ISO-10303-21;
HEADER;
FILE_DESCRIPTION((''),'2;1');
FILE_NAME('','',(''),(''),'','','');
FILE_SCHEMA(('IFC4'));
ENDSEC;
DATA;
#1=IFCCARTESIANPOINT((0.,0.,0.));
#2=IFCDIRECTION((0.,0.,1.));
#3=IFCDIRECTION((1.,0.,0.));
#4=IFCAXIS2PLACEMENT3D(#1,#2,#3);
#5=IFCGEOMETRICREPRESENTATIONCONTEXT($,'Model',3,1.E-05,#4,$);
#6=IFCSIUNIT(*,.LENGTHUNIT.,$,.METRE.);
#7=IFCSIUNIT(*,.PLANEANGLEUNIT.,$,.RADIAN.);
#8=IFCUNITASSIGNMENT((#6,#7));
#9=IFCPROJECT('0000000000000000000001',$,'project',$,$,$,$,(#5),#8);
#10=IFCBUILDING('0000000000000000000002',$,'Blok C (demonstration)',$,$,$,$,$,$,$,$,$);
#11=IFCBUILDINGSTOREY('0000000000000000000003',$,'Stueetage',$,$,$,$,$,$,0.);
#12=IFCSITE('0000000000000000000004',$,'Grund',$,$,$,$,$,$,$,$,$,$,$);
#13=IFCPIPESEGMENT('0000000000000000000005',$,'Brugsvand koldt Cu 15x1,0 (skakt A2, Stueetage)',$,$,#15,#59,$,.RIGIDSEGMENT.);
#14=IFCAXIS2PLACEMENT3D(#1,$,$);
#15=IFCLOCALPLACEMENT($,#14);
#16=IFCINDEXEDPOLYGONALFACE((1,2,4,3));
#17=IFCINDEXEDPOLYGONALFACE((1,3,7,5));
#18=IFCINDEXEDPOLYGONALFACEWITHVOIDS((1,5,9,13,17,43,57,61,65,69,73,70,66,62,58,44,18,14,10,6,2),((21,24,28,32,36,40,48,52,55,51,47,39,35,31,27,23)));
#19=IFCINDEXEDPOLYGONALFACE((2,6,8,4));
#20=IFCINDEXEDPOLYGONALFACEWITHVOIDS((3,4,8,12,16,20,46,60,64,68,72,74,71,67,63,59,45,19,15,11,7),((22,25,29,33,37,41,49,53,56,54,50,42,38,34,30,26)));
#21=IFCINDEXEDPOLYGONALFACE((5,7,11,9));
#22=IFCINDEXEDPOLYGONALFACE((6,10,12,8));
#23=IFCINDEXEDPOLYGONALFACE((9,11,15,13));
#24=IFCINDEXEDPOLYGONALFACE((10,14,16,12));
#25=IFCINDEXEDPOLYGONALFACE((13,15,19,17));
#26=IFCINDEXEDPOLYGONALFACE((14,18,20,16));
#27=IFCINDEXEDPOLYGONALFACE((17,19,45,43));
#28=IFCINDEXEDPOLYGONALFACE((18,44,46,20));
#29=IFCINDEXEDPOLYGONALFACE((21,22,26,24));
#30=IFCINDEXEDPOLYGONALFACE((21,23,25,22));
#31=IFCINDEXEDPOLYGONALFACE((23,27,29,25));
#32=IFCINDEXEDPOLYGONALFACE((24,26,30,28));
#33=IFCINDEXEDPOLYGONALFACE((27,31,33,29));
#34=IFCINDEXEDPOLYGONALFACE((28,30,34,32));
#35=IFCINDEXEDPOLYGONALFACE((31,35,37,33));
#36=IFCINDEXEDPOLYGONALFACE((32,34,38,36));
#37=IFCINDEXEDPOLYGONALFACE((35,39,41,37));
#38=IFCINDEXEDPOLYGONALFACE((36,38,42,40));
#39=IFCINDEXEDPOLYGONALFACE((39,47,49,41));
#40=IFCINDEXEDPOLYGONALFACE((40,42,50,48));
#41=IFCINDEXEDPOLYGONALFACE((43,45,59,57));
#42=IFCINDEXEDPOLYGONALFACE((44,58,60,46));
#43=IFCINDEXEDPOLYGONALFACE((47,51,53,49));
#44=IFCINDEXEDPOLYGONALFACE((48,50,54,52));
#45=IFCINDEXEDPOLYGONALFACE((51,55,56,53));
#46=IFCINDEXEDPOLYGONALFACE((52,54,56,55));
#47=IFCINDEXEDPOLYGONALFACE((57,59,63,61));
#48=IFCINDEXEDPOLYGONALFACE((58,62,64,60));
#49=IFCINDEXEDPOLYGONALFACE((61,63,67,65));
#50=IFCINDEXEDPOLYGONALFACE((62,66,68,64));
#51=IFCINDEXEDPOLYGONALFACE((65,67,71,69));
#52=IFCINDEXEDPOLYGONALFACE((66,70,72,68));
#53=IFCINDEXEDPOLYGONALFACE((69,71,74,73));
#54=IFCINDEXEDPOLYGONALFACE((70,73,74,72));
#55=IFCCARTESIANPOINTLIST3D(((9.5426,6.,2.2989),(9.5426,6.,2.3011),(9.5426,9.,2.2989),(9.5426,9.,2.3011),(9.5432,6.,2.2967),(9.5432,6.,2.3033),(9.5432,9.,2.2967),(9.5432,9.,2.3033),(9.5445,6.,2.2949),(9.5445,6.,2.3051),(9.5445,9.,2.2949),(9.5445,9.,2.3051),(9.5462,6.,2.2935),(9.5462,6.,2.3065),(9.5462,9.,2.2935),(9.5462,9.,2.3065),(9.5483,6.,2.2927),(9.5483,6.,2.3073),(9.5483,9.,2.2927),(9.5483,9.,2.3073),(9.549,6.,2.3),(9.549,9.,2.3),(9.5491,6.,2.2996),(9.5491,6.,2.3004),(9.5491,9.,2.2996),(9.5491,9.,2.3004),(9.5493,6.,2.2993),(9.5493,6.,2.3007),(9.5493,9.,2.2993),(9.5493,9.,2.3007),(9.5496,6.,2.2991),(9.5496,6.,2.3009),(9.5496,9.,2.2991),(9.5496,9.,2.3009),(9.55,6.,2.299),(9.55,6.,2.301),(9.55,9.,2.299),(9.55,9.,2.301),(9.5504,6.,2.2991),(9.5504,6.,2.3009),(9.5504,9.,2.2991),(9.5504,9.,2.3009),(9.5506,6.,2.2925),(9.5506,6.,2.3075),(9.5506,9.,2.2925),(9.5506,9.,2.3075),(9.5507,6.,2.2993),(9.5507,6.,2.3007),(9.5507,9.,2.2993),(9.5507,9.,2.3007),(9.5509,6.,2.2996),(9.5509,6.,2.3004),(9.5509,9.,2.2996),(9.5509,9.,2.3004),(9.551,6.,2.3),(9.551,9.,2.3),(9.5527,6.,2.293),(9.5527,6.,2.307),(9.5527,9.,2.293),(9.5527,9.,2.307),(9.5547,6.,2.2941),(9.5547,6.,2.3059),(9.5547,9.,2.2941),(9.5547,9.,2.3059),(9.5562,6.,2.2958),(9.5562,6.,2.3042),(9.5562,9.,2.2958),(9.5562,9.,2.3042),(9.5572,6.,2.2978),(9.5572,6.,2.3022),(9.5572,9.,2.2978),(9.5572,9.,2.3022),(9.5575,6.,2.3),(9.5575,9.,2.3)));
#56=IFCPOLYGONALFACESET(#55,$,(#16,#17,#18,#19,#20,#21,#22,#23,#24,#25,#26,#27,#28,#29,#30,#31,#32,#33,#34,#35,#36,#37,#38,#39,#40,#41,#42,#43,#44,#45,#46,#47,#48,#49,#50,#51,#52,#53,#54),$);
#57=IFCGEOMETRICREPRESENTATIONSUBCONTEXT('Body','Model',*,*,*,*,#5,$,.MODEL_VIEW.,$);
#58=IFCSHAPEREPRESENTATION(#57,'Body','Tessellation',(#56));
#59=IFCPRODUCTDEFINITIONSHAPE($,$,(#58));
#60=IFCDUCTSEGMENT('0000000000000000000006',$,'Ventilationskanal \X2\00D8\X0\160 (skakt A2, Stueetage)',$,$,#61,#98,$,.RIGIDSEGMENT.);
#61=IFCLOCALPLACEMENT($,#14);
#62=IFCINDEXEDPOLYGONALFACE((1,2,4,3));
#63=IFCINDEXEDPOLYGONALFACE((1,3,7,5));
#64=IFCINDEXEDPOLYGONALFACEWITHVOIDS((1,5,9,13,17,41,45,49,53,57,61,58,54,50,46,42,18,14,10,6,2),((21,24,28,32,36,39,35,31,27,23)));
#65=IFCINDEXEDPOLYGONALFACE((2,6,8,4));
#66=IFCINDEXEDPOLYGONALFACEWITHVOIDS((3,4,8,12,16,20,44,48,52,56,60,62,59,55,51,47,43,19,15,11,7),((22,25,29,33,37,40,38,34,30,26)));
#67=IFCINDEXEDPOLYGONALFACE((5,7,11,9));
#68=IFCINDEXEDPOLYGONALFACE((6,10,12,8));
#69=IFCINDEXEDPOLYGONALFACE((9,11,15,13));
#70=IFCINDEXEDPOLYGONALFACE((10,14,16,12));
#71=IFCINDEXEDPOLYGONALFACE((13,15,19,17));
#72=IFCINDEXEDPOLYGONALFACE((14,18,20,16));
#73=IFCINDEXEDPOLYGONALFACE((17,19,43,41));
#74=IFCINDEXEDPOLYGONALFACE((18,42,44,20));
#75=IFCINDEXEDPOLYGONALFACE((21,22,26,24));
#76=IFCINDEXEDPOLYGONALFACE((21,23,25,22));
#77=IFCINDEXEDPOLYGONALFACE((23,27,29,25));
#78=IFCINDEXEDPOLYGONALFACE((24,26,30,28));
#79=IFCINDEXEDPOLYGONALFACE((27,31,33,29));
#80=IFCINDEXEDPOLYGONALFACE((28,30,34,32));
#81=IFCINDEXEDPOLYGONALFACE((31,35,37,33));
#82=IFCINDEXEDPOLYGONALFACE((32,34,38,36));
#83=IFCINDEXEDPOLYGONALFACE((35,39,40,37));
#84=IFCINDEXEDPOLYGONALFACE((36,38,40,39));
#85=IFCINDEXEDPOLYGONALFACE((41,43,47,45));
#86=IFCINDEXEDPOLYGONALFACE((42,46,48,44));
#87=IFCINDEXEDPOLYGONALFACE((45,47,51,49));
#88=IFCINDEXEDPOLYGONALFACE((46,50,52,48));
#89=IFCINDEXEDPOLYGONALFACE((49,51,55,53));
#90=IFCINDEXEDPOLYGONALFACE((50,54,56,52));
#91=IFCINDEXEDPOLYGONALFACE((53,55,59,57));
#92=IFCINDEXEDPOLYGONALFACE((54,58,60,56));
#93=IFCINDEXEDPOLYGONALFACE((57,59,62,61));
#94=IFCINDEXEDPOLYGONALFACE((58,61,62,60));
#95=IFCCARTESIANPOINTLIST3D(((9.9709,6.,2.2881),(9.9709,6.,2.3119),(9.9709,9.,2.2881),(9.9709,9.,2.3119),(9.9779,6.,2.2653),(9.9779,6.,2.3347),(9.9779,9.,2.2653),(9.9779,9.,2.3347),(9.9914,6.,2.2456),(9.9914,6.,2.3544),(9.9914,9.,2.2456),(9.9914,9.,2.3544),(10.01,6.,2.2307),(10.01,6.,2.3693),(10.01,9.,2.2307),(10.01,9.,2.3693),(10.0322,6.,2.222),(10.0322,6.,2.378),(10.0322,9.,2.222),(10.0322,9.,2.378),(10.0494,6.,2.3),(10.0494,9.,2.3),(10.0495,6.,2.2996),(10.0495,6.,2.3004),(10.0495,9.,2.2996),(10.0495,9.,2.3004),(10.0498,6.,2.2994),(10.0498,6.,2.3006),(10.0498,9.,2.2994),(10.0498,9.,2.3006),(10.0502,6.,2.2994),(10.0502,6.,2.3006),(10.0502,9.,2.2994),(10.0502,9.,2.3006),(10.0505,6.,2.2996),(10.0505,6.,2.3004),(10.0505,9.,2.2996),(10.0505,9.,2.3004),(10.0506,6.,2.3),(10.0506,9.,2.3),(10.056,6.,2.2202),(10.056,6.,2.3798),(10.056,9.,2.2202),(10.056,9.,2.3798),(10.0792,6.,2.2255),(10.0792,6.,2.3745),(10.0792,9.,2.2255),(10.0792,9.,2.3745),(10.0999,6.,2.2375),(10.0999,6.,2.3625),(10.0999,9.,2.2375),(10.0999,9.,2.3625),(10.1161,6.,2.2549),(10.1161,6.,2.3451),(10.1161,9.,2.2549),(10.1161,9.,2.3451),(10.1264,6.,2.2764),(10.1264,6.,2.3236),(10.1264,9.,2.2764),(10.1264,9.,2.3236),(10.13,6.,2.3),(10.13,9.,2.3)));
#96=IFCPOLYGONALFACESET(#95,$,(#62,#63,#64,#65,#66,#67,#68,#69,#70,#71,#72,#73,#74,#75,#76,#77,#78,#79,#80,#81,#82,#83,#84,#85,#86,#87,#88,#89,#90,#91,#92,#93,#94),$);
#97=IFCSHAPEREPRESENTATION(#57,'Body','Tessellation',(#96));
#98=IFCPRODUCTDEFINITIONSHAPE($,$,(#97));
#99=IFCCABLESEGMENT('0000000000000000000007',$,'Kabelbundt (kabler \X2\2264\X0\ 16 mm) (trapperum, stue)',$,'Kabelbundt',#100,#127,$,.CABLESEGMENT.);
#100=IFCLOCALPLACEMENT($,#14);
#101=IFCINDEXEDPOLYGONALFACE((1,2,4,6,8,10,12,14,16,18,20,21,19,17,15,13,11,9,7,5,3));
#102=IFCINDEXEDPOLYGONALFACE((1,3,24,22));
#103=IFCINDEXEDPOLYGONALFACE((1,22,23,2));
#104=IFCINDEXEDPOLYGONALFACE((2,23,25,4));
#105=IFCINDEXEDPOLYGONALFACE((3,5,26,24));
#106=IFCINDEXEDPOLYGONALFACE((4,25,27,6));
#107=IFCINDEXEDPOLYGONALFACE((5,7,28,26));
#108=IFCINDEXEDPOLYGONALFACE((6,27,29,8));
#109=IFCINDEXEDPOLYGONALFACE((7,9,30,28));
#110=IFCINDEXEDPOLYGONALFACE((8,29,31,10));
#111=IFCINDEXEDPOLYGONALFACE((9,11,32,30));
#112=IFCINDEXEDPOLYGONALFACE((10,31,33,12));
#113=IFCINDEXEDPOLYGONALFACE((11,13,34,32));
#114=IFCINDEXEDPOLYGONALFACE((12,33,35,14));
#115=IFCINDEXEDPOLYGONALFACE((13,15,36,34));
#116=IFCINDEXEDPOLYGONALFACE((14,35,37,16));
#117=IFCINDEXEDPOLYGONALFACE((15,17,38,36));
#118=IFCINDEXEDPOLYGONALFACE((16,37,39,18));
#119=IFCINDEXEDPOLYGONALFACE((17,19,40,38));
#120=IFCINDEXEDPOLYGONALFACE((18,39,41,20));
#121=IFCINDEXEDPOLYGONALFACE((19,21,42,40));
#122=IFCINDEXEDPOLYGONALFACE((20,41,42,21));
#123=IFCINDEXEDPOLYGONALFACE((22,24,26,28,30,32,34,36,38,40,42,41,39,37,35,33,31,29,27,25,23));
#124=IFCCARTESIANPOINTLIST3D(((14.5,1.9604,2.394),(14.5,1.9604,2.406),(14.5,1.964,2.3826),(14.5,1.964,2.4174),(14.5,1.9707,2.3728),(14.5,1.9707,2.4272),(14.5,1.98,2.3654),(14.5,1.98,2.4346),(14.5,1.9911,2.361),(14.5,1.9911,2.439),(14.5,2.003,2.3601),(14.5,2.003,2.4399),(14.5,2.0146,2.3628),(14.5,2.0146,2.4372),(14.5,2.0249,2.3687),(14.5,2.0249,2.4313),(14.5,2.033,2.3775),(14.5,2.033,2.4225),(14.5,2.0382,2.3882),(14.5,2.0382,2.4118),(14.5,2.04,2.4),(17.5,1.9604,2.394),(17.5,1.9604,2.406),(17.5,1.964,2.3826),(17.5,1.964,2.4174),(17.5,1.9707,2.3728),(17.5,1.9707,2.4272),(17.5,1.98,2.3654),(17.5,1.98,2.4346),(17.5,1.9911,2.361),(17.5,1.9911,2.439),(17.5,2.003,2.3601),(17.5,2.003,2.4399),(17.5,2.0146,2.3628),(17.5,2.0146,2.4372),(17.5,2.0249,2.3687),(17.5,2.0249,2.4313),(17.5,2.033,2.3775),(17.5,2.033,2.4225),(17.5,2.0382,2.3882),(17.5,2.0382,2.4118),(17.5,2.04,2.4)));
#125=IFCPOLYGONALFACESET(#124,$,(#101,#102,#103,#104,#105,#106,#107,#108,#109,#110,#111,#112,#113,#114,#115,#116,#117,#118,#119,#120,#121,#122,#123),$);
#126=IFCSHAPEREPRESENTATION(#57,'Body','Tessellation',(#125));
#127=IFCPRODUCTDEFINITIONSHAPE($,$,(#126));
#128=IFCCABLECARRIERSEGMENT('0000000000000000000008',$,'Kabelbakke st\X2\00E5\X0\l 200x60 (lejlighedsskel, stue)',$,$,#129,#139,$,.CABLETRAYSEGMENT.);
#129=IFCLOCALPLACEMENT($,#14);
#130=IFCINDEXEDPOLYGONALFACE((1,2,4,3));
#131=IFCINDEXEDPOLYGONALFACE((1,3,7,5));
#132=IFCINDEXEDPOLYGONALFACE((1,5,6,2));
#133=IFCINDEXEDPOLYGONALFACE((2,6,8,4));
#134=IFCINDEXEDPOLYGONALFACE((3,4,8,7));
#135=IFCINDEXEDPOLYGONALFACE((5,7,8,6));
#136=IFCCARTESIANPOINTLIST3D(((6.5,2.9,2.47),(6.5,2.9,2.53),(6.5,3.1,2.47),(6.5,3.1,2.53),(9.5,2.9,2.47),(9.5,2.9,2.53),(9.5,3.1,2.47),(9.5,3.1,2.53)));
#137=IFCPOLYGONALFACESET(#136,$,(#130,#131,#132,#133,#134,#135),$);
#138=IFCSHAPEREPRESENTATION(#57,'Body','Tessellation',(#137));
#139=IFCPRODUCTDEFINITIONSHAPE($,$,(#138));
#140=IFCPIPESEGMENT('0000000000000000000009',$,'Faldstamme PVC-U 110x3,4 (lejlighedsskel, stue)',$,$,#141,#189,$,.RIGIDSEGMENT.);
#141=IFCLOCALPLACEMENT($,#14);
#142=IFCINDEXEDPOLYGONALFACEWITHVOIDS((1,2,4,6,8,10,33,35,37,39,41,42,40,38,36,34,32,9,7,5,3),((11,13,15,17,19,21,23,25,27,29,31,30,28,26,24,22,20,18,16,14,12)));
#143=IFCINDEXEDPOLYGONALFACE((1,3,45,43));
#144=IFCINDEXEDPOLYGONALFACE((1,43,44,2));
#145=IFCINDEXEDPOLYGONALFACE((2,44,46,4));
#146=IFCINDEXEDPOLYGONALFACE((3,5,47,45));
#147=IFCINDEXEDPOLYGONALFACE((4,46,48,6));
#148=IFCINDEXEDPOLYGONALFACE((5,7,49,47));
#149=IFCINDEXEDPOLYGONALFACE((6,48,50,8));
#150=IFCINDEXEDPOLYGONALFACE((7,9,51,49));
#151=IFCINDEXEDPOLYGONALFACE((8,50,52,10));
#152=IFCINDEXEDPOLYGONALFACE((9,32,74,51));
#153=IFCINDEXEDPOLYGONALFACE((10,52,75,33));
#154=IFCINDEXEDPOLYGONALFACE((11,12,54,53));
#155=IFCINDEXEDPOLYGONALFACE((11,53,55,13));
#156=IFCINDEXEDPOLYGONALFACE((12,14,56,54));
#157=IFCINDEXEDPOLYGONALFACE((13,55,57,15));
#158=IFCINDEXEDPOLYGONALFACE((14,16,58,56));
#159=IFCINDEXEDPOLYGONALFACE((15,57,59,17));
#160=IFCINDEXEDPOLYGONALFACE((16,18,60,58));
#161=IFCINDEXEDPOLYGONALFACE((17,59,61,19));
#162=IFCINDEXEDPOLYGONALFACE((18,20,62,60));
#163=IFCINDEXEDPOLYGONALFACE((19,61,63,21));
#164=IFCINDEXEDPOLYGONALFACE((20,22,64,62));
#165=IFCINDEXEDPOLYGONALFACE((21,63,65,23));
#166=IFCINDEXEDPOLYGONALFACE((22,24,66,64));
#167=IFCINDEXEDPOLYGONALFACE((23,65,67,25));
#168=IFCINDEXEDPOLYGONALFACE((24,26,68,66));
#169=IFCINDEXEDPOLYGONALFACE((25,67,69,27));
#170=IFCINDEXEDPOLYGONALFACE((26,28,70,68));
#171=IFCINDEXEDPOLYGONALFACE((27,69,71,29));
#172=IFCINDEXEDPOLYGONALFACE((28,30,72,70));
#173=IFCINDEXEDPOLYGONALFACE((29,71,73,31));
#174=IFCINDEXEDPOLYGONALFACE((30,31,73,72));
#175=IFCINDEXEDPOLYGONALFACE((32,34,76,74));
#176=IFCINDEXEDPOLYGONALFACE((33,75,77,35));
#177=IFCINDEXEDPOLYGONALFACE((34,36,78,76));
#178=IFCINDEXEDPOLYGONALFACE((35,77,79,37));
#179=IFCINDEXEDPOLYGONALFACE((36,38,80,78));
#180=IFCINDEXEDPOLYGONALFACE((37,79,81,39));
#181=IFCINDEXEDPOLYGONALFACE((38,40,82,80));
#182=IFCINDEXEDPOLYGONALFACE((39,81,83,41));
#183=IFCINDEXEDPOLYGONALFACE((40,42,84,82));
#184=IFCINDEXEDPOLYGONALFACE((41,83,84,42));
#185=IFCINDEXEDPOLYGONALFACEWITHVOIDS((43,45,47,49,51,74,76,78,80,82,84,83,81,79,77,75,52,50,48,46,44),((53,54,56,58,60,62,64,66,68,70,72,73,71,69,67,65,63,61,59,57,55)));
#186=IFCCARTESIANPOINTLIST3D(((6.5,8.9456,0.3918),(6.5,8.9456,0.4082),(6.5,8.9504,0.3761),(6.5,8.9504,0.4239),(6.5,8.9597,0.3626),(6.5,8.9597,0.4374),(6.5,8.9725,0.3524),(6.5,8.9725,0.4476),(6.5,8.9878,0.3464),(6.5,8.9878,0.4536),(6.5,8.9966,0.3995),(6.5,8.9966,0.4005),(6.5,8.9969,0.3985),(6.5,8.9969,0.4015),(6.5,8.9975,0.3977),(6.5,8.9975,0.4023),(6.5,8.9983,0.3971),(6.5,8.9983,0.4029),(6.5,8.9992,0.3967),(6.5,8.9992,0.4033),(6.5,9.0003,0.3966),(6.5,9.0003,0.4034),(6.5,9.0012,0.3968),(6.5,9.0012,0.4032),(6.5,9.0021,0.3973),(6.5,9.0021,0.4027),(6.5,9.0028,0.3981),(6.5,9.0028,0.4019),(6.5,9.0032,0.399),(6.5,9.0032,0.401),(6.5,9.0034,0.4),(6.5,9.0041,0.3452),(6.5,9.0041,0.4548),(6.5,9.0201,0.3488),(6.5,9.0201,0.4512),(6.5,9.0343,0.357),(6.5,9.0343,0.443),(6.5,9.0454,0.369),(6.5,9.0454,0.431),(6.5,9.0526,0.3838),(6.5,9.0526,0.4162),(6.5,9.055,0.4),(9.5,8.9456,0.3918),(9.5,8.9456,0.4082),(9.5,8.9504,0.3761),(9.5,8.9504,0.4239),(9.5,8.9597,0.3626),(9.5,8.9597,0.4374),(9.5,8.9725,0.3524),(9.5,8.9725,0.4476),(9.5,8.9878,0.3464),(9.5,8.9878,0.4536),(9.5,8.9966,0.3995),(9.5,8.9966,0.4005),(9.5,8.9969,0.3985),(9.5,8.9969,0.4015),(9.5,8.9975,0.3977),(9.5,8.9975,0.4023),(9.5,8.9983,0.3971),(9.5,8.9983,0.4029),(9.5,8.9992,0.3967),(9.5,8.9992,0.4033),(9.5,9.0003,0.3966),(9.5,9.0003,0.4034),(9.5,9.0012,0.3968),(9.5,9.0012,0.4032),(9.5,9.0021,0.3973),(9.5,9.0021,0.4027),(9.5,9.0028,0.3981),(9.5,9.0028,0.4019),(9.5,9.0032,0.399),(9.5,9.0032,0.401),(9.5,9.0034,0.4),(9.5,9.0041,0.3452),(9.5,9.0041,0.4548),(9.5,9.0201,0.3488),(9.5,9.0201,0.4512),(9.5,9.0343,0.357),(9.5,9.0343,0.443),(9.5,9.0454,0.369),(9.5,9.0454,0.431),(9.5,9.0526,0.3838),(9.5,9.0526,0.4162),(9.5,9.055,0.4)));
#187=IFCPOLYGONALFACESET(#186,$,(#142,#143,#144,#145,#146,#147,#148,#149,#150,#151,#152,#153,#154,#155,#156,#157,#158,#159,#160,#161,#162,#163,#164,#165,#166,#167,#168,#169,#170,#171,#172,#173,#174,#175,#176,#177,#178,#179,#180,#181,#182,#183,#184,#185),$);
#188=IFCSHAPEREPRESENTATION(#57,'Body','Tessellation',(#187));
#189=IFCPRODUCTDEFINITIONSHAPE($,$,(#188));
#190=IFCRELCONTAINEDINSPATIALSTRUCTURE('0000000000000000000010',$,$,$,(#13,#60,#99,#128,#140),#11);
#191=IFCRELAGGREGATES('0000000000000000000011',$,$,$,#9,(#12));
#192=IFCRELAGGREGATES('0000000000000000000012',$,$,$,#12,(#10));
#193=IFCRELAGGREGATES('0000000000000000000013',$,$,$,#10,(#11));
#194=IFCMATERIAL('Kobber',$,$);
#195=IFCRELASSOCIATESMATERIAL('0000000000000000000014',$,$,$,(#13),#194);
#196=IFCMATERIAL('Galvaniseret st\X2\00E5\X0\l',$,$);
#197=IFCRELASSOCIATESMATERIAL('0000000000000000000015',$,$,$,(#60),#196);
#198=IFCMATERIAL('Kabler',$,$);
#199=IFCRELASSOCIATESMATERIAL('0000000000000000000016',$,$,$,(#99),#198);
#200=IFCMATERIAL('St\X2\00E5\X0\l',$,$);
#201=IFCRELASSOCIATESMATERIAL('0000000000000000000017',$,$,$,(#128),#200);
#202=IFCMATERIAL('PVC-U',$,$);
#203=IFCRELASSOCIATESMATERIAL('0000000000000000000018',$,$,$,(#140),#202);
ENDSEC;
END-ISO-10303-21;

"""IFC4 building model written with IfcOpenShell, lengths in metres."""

from ifc_helpers import new_model, si_unit, frame, origin_with_axes, place, context, subcontext, project, spatial, polyline, circle, hollow_circle, outline, extrude, material, element, save


model = new_model("IFC4")

# Units and contexts
model_context = context("Model", 3, precision=1e-05, world=origin_with_axes())
body_context = subcontext(model_context, "Body", "Model", "MODEL_VIEW")
ifc_project = project(units=[si_unit("LENGTHUNIT", "METRE"), si_unit("PLANEANGLEUNIT", "RADIAN")], contexts=[model_context])

# Site, building, storey
site = spatial("IfcSite", under=ifc_project, Name="Grund")
building = spatial("IfcBuilding", under=site, Name="Blok C (demonstration)")
storey = spatial("IfcBuildingStorey", under=building, Name="Stueetage", Elevation=0.0)

# Pipe segment
ifc_material_1 = material(Name="PVC-U")
ifc_material_2 = material(Name="Kobber")
ifc_material_3 = material(Name="Stål")
pipe_segment_1_placement = place(None, origin_with_axes())
element("IfcPipeSegment", 1, at=pipe_segment_1_placement, inside=storey, material=ifc_material_2, Name="Brugsvand koldt Cu 15x1,0 (skakt A2, Stueetage)", PredefinedType="RIGIDSEGMENT", context=body_context, shape_type="SweptSolid", body=[
    extrude(hollow_circle(Radius=0.0075, WallThickness=0.0065), frame((9.55, 6.0, 2.3), z_axis=(0.0, 1.0, 0.0), x_axis=(1.0, 0.0, 0.0)), (0.0, 0.0, 1.0), 3.0),
])

# Duct segment
ifc_material_4 = material(Name="Galvaniseret stål")
duct_segment_placement = place(None, origin_with_axes())
element("IfcDuctSegment", 2, at=duct_segment_placement, inside=storey, material=ifc_material_4, Name="Ventilationskanal Ø160 (skakt A2, Stueetage)", PredefinedType="RIGIDSEGMENT", context=body_context, shape_type="SweptSolid", body=[
    extrude(hollow_circle(Radius=0.08, WallThickness=0.0794), frame((10.05, 6.0, 2.3), z_axis=(0.0, 1.0, 0.0), x_axis=(1.0, 0.0, 0.0)), (0.0, 0.0, 1.0), 3.0),
])

# Cable segment
ifc_material_5 = material(Name="Kabler")
cable_segment_placement = place(None, origin_with_axes())
element("IfcCableSegment", 3, at=cable_segment_placement, inside=storey, material=ifc_material_5, Name="Kabelbundt (kabler ≤ 16 mm) (trapperum, stue)", ObjectType="Kabelbundt", PredefinedType="CABLESEGMENT", context=body_context, shape_type="SweptSolid", body=[
    extrude(circle(Radius=0.04), frame((14.5, 2.0, 2.4), z_axis=(1.0, 0.0, 0.0), x_axis=(0.0, 1.0, 0.0)), (0.0, 0.0, 1.0), 3.0),
])

# Cable carrier segment
cable_carrier_segment_placement = place(None, origin_with_axes())
element("IfcCableCarrierSegment", 4, at=cable_carrier_segment_placement, inside=storey, material=ifc_material_3, Name="Kabelbakke stål 200x60 (lejlighedsskel, stue)", PredefinedType="CABLETRAYSEGMENT", context=body_context, shape_type="SweptSolid", body=[
    extrude(outline(polyline([(6.5, 2.9), (9.5, 2.9), (9.5, 3.1), (6.5, 3.1), (6.5, 2.9)])), frame((0.0, 0.0, 2.47)), (0.0, 0.0, 1.0), 0.06),
])

# Pipe segment
pipe_segment_2_placement = place(None, origin_with_axes())
element("IfcPipeSegment", 5, at=pipe_segment_2_placement, inside=storey, material=ifc_material_1, Name="Faldstamme PVC-U 110x3,4 (lejlighedsskel, stue)", PredefinedType="RIGIDSEGMENT", context=body_context, shape_type="SweptSolid", body=[
    extrude(hollow_circle(Radius=0.055, WallThickness=0.0516), frame((6.5, 9.0, 0.4), z_axis=(1.0, 0.0, 0.0), x_axis=(0.0, 1.0, 0.0)), (0.0, 0.0, 1.0), 3.0),
])

save(model, "model.ifc")
